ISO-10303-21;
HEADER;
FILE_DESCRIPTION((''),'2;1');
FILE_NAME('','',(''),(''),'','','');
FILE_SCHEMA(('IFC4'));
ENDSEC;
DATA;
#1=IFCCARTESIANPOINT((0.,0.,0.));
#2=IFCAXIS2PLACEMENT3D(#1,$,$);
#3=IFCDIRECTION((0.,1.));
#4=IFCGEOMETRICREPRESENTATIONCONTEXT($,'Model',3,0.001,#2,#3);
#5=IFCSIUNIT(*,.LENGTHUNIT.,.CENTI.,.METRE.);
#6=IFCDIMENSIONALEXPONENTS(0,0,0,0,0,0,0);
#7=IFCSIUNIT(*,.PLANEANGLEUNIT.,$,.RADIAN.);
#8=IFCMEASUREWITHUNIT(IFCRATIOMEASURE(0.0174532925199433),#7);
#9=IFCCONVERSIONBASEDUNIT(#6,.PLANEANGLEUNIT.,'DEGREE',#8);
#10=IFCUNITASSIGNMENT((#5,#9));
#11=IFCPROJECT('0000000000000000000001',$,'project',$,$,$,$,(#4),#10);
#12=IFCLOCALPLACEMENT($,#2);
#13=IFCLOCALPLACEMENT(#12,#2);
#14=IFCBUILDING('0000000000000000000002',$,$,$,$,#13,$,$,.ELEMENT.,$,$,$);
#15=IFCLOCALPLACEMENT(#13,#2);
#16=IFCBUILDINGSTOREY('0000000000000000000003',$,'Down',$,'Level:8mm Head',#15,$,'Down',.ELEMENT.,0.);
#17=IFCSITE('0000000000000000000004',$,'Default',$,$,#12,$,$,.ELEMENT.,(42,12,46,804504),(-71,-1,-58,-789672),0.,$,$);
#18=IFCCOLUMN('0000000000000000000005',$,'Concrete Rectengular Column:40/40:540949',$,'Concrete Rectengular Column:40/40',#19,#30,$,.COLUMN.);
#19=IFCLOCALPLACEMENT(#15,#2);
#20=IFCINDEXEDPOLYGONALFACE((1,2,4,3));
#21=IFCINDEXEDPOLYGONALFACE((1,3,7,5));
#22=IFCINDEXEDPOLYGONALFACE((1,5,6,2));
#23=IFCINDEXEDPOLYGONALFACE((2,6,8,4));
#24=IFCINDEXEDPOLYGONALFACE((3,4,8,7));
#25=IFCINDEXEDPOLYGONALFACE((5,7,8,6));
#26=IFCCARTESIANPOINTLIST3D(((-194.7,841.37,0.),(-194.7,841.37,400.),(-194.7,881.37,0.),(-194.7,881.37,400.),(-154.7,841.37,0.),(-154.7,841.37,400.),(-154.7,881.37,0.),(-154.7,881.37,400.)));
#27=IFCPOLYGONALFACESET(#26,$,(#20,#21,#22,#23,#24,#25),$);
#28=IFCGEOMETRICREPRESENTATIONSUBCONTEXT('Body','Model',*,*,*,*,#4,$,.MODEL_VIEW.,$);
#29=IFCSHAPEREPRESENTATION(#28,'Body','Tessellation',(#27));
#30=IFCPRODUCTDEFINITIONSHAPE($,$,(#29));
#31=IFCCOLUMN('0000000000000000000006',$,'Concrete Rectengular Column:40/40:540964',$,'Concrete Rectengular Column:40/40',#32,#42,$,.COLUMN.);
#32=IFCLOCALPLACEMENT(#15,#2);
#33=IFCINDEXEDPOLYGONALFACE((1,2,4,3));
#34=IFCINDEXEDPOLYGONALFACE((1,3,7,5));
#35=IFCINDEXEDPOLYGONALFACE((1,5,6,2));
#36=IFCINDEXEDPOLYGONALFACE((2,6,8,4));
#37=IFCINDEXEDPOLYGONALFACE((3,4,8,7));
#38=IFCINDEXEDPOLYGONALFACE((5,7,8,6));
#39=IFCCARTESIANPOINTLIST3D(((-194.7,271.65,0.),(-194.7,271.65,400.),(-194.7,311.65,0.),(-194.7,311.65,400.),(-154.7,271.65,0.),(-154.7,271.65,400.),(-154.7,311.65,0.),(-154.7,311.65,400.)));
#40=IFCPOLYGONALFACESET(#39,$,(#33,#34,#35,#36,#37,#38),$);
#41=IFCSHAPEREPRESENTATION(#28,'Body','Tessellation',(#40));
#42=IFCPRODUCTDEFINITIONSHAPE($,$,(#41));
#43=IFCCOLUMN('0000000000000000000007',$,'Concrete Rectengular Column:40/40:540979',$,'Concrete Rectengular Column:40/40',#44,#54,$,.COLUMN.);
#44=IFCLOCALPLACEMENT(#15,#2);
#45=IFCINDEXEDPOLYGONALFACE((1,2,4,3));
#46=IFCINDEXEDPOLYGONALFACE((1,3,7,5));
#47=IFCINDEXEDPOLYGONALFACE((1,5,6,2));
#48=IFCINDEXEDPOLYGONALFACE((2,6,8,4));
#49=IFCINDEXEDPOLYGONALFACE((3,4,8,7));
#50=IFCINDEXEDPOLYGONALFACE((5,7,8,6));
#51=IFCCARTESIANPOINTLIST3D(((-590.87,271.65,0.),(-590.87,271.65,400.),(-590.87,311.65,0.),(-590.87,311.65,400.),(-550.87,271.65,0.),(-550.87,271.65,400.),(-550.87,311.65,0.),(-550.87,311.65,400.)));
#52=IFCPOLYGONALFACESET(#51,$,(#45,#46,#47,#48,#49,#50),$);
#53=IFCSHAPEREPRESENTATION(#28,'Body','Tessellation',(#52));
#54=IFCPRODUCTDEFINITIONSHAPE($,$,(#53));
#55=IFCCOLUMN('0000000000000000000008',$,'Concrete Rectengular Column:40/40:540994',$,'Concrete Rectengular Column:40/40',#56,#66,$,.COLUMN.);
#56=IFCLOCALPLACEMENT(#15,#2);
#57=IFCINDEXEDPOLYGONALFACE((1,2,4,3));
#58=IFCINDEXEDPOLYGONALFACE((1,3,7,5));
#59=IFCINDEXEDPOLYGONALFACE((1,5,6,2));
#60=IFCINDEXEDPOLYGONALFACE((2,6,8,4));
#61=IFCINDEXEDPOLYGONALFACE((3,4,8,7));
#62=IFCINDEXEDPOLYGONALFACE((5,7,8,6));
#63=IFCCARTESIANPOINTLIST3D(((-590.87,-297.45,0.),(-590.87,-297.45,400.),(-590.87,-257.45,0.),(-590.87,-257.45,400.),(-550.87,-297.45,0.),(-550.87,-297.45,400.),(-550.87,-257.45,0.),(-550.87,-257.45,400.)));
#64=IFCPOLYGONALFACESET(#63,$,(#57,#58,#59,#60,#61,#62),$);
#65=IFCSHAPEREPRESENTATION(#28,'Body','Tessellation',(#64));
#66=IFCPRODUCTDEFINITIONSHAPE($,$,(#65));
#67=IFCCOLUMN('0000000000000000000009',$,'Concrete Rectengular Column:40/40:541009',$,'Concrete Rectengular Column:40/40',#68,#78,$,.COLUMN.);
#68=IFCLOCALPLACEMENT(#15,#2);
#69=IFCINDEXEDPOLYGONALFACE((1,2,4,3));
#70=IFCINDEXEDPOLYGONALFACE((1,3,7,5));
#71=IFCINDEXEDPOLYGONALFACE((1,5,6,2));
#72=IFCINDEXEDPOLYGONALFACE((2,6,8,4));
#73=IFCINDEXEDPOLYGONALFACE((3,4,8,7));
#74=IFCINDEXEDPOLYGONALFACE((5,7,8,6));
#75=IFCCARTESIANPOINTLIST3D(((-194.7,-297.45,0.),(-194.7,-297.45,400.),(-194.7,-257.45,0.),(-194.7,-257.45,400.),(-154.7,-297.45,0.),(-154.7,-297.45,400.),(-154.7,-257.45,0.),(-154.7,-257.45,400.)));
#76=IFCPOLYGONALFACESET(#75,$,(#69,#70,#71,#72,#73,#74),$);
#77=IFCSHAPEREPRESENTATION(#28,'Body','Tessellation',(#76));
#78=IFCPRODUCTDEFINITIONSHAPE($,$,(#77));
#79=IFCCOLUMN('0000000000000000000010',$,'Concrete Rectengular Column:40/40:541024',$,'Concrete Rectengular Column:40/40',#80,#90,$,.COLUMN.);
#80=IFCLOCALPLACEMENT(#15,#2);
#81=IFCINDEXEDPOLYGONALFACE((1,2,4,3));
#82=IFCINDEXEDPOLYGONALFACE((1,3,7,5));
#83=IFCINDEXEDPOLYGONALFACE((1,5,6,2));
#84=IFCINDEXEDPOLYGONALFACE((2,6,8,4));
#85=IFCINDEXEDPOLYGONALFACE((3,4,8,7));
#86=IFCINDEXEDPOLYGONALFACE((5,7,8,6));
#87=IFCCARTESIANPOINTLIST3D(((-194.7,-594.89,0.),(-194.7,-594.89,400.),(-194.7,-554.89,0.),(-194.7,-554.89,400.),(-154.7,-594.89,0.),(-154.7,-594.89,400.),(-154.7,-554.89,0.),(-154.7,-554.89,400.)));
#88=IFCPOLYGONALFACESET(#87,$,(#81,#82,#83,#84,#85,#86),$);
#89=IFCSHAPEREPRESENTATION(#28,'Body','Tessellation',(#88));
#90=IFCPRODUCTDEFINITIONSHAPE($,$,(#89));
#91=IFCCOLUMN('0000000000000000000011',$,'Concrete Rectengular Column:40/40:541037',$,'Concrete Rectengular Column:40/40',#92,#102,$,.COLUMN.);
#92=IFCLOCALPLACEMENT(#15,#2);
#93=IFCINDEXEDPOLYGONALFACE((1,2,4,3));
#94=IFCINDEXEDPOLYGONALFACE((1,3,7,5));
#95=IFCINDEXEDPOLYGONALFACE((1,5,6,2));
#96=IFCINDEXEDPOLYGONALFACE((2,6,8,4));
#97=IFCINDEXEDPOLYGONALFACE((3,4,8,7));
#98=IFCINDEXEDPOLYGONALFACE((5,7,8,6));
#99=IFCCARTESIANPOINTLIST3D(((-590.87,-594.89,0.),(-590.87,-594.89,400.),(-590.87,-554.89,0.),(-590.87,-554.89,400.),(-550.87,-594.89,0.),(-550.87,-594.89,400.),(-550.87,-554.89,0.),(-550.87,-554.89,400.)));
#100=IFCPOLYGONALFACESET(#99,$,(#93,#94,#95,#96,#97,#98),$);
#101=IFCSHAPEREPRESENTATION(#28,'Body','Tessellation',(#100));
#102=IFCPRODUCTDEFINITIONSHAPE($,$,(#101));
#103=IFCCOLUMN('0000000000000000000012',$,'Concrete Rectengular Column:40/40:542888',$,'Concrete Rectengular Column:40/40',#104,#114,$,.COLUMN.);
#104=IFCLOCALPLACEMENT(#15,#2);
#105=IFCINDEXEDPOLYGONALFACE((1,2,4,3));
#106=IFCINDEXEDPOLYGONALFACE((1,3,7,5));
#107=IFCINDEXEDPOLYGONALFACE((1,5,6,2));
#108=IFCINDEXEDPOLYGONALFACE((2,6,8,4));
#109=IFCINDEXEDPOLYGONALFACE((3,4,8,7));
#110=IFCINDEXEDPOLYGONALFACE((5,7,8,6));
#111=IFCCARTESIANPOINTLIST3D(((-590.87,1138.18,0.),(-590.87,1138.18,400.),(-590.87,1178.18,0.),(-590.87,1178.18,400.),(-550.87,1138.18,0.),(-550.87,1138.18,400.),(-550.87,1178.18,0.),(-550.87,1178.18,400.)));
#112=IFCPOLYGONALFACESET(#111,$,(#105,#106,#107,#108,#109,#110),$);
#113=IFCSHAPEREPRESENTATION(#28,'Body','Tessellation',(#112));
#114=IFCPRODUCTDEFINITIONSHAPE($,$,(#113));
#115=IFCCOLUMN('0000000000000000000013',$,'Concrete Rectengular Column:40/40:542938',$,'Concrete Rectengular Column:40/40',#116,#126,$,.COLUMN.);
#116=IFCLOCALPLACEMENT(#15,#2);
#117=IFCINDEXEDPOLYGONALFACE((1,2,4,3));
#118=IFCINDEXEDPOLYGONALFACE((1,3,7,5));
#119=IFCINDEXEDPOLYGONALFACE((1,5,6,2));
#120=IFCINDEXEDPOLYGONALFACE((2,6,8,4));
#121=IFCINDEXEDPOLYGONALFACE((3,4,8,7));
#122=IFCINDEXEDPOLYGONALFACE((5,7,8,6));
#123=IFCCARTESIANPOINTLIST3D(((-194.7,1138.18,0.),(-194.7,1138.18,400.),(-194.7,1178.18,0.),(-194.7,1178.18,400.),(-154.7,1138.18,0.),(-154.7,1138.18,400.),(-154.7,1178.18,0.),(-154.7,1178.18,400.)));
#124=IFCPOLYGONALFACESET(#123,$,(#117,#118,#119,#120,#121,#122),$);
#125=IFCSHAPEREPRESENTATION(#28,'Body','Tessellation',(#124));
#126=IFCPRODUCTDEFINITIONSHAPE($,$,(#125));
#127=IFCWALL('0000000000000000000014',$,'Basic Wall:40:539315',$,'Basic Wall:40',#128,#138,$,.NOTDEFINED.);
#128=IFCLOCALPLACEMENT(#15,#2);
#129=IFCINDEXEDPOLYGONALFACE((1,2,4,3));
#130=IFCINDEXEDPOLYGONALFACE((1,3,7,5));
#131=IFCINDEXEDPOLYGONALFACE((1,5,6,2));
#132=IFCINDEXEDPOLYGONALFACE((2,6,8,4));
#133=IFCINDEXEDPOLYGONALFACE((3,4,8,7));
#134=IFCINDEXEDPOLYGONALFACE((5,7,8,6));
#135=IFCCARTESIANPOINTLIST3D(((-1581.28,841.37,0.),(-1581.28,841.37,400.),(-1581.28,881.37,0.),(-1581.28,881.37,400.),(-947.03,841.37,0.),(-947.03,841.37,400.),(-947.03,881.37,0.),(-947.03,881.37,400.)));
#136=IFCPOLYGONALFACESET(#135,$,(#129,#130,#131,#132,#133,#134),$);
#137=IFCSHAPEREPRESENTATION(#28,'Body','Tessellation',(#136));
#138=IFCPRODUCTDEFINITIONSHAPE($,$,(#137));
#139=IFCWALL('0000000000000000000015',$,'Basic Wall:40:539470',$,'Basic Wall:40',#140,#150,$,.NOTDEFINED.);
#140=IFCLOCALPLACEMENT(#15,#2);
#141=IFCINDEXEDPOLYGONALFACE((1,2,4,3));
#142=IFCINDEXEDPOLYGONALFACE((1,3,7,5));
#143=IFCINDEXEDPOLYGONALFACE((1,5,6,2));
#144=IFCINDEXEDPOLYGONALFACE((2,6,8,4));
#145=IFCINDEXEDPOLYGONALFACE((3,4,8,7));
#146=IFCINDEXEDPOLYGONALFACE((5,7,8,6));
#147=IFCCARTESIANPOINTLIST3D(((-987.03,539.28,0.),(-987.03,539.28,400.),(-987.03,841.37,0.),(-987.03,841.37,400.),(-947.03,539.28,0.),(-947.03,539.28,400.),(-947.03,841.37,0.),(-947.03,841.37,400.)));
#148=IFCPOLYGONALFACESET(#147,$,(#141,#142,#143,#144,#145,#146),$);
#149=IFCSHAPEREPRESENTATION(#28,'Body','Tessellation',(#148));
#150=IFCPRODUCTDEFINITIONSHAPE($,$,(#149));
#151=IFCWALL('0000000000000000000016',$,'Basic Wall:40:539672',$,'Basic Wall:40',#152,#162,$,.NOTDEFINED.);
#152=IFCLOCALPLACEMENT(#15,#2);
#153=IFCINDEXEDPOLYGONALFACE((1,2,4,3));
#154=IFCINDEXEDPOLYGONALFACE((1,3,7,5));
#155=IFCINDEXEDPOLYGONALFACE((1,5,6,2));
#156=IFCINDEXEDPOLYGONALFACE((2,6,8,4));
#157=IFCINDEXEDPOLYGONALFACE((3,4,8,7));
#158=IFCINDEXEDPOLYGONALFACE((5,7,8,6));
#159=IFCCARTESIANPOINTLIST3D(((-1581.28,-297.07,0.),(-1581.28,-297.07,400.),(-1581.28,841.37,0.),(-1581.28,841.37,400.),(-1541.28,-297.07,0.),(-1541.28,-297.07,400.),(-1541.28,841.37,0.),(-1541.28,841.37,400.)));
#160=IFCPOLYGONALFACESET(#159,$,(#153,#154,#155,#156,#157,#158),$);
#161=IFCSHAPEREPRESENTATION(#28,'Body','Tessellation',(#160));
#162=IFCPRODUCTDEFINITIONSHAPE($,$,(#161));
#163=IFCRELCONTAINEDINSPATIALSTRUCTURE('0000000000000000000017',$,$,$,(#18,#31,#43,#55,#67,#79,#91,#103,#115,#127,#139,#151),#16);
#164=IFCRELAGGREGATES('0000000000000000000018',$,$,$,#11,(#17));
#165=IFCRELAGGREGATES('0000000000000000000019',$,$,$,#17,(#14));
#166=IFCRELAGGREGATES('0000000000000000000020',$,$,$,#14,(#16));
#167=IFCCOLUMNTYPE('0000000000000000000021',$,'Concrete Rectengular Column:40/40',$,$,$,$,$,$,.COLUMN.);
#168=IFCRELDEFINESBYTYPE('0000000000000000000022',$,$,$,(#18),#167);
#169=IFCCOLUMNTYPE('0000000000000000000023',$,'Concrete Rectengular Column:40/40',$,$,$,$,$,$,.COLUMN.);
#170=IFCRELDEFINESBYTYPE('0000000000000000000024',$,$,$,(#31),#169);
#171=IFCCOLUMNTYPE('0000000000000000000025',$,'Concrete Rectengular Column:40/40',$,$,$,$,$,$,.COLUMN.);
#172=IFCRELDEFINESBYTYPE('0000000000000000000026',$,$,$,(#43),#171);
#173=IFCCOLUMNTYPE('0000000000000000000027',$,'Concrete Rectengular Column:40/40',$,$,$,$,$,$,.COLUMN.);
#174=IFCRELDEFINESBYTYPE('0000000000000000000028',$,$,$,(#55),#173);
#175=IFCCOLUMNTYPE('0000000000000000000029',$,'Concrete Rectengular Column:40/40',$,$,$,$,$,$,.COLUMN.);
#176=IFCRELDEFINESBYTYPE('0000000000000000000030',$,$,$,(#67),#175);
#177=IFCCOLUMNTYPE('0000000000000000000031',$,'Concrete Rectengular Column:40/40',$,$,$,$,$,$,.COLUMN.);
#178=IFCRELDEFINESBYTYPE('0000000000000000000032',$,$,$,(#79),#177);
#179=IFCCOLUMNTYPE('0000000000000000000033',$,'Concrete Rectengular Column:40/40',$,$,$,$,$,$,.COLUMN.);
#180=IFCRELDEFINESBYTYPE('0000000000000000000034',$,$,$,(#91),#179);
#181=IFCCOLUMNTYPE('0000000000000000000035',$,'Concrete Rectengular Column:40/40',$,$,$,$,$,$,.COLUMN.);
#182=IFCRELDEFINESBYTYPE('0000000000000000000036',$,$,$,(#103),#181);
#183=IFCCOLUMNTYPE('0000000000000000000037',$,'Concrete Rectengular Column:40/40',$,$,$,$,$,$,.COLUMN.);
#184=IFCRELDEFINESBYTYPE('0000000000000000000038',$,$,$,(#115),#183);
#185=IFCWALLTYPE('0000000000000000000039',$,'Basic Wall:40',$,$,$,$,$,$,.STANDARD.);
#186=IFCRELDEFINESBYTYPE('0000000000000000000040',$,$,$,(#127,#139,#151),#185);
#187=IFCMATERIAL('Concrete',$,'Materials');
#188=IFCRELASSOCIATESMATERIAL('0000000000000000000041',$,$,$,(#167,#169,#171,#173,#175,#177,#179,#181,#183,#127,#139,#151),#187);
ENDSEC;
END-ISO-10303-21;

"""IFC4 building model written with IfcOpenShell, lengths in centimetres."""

from ifc_helpers import new_model, entity, si_unit, converted_unit, direction, frame, origin, place, context, subcontext, project, spatial, indexed_curve, outline, extrude, source, transform, mapped, material, type_object, type_shapes, element, save


model = new_model("IFC4")

# Units and contexts
model_context = context("Model", 3, precision=0.001, world=origin(), true_north=direction((0.0, 1.0)))
body_context = subcontext(model_context, "Body", "Model", "MODEL_VIEW")
ifc_project = project(units=[si_unit("LENGTHUNIT", "METRE", prefix="CENTI"), converted_unit("PLANEANGLEUNIT", "DEGREE", entity("IfcRatioMeasure", 0.0174532925199433), si_unit("PLANEANGLEUNIT", "RADIAN"), dimensions=[0, 0, 0, 0, 0, 0, 0])], contexts=[model_context])

# Site, building, storey
site_placement = place(None, origin())
site = spatial("IfcSite", under=ifc_project, at=site_placement, Name="Default", CompositionType="ELEMENT", RefLatitude=(42, 12, 46, 804504), RefLongitude=(-71, -1, -58, -789672), RefElevation=0.0)
building_placement = place(site_placement, origin())
building = spatial("IfcBuilding", under=site, at=building_placement, CompositionType="ELEMENT")
storey_placement = place(building_placement, origin())
storey = spatial("IfcBuildingStorey", under=building, at=storey_placement, Name="Down", ObjectType="Level:8mm Head", LongName="Down", CompositionType="ELEMENT", Elevation=0.0)

# Columns
ifc_material = material(Name="Concrete", Category="Materials")
column_type_1 = type_object("IfcColumnType", Name="Concrete Rectengular Column:40/40", PredefinedType="COLUMN", material=ifc_material)
shared_shape_1 = source(origin(), body_context, "Body", "SweptSolid", [
    extrude(outline(indexed_curve([(-20.0, -20.0), (20.0, -20.0), (20.0, 20.0), (-20.0, 20.0), (-20.0, -20.0)], self_intersect=False)), frame((-174.7, 861.37, 0.0), z_axis=(0.0, 0.0, 1.0), x_axis=(0.0, -1.0, 0.0)), (0.0, 0.0, 1.0), 400.0),
])
type_shapes(column_type_1, [shared_shape_1])
column_1_placement = place(storey_placement, origin())
element("IfcColumn", 1, at=column_1_placement, inside=storey, type_object=column_type_1, Name="Concrete Rectengular Column:40/40:540949", ObjectType="Concrete Rectengular Column:40/40", PredefinedType="COLUMN", context=body_context, shape_type="MappedRepresentation", body=[
    mapped(shared_shape_1, transform((0.0, 0.0, 0.0), scale=1.0)),
])
column_type_2 = type_object("IfcColumnType", Name="Concrete Rectengular Column:40/40", PredefinedType="COLUMN", material=ifc_material)
shared_shape_2 = source(origin(), body_context, "Body", "SweptSolid", [
    extrude(outline(indexed_curve([(-20.0, -20.0), (20.0, -20.0), (20.0, 20.0), (-20.0, 20.0), (-20.0, -20.0)], self_intersect=False)), frame((-174.7, 291.65, 0.0), z_axis=(0.0, 0.0, 1.0), x_axis=(0.0, -1.0, 0.0)), (0.0, 0.0, 1.0), 400.0),
])
type_shapes(column_type_2, [shared_shape_2])
column_2_placement = place(storey_placement, origin())
element("IfcColumn", 2, at=column_2_placement, inside=storey, type_object=column_type_2, Name="Concrete Rectengular Column:40/40:540964", ObjectType="Concrete Rectengular Column:40/40", PredefinedType="COLUMN", context=body_context, shape_type="MappedRepresentation", body=[
    mapped(shared_shape_2, transform((0.0, 0.0, 0.0), scale=1.0)),
])
column_type_3 = type_object("IfcColumnType", Name="Concrete Rectengular Column:40/40", PredefinedType="COLUMN", material=ifc_material)
shared_shape_3 = source(origin(), body_context, "Body", "SweptSolid", [
    extrude(outline(indexed_curve([(-20.0, -20.0), (20.0, -20.0), (20.0, 20.0), (-20.0, 20.0), (-20.0, -20.0)], self_intersect=False)), frame((-570.87, 291.65, 0.0), z_axis=(0.0, 0.0, 1.0), x_axis=(0.0, -1.0, 0.0)), (0.0, 0.0, 1.0), 400.0),
])
type_shapes(column_type_3, [shared_shape_3])
column_3_placement = place(storey_placement, origin())
element("IfcColumn", 3, at=column_3_placement, inside=storey, type_object=column_type_3, Name="Concrete Rectengular Column:40/40:540979", ObjectType="Concrete Rectengular Column:40/40", PredefinedType="COLUMN", context=body_context, shape_type="MappedRepresentation", body=[
    mapped(shared_shape_3, transform((0.0, 0.0, 0.0), scale=1.0)),
])
column_type_4 = type_object("IfcColumnType", Name="Concrete Rectengular Column:40/40", PredefinedType="COLUMN", material=ifc_material)
shared_shape_4 = source(origin(), body_context, "Body", "SweptSolid", [
    extrude(outline(indexed_curve([(-20.0, -20.0), (20.0, -20.0), (20.0, 20.0), (-20.0, 20.0), (-20.0, -20.0)], self_intersect=False)), frame((-570.87, -277.45, 0.0), z_axis=(0.0, 0.0, 1.0), x_axis=(0.0, -1.0, 0.0)), (0.0, 0.0, 1.0), 400.0),
])
type_shapes(column_type_4, [shared_shape_4])
column_4_placement = place(storey_placement, origin())
element("IfcColumn", 4, at=column_4_placement, inside=storey, type_object=column_type_4, Name="Concrete Rectengular Column:40/40:540994", ObjectType="Concrete Rectengular Column:40/40", PredefinedType="COLUMN", context=body_context, shape_type="MappedRepresentation", body=[
    mapped(shared_shape_4, transform((0.0, 0.0, 0.0), scale=1.0)),
])
column_type_5 = type_object("IfcColumnType", Name="Concrete Rectengular Column:40/40", PredefinedType="COLUMN", material=ifc_material)
shared_shape_5 = source(origin(), body_context, "Body", "SweptSolid", [
    extrude(outline(indexed_curve([(-20.0, -20.0), (20.0, -20.0), (20.0, 20.0), (-20.0, 20.0), (-20.0, -20.0)], self_intersect=False)), frame((-174.7, -277.45, 0.0), z_axis=(0.0, 0.0, 1.0), x_axis=(0.0, -1.0, 0.0)), (0.0, 0.0, 1.0), 400.0),
])
type_shapes(column_type_5, [shared_shape_5])
column_5_placement = place(storey_placement, origin())
element("IfcColumn", 5, at=column_5_placement, inside=storey, type_object=column_type_5, Name="Concrete Rectengular Column:40/40:541009", ObjectType="Concrete Rectengular Column:40/40", PredefinedType="COLUMN", context=body_context, shape_type="MappedRepresentation", body=[
    mapped(shared_shape_5, transform((0.0, 0.0, 0.0), scale=1.0)),
])
column_type_6 = type_object("IfcColumnType", Name="Concrete Rectengular Column:40/40", PredefinedType="COLUMN", material=ifc_material)
shared_shape_6 = source(origin(), body_context, "Body", "SweptSolid", [
    extrude(outline(indexed_curve([(-20.0, -20.0), (20.0, -20.0), (20.0, 20.0), (-20.0, 20.0), (-20.0, -20.0)], self_intersect=False)), frame((-174.7, -574.89, 0.0), z_axis=(0.0, 0.0, 1.0), x_axis=(0.0, -1.0, 0.0)), (0.0, 0.0, 1.0), 400.0),
])
type_shapes(column_type_6, [shared_shape_6])
column_6_placement = place(storey_placement, origin())
element("IfcColumn", 6, at=column_6_placement, inside=storey, type_object=column_type_6, Name="Concrete Rectengular Column:40/40:541024", ObjectType="Concrete Rectengular Column:40/40", PredefinedType="COLUMN", context=body_context, shape_type="MappedRepresentation", body=[
    mapped(shared_shape_6, transform((0.0, 0.0, 0.0), scale=1.0)),
])
column_type_7 = type_object("IfcColumnType", Name="Concrete Rectengular Column:40/40", PredefinedType="COLUMN", material=ifc_material)
shared_shape_7 = source(origin(), body_context, "Body", "SweptSolid", [
    extrude(outline(indexed_curve([(-20.0, -20.0), (20.0, -20.0), (20.0, 20.0), (-20.0, 20.0), (-20.0, -20.0)], self_intersect=False)), frame((-570.87, -574.89, 0.0), z_axis=(0.0, 0.0, 1.0), x_axis=(0.0, -1.0, 0.0)), (0.0, 0.0, 1.0), 400.0),
])
type_shapes(column_type_7, [shared_shape_7])
column_7_placement = place(storey_placement, origin())
element("IfcColumn", 7, at=column_7_placement, inside=storey, type_object=column_type_7, Name="Concrete Rectengular Column:40/40:541037", ObjectType="Concrete Rectengular Column:40/40", PredefinedType="COLUMN", context=body_context, shape_type="MappedRepresentation", body=[
    mapped(shared_shape_7, transform((0.0, 0.0, 0.0), scale=1.0)),
])
column_type_8 = type_object("IfcColumnType", Name="Concrete Rectengular Column:40/40", PredefinedType="COLUMN", material=ifc_material)
shared_shape_8 = source(origin(), body_context, "Body", "SweptSolid", [
    extrude(outline(indexed_curve([(-20.0, -20.0), (20.0, -20.0), (20.0, 20.0), (-20.0, 20.0), (-20.0, -20.0)], self_intersect=False)), frame((-570.87, 1158.18, 0.0), z_axis=(0.0, 0.0, 1.0), x_axis=(0.0, -1.0, 0.0)), (0.0, 0.0, 1.0), 400.0),
])
type_shapes(column_type_8, [shared_shape_8])
column_8_placement = place(storey_placement, origin())
element("IfcColumn", 8, at=column_8_placement, inside=storey, type_object=column_type_8, Name="Concrete Rectengular Column:40/40:542888", ObjectType="Concrete Rectengular Column:40/40", PredefinedType="COLUMN", context=body_context, shape_type="MappedRepresentation", body=[
    mapped(shared_shape_8, transform((0.0, 0.0, 0.0), scale=1.0)),
])
column_type_9 = type_object("IfcColumnType", Name="Concrete Rectengular Column:40/40", PredefinedType="COLUMN", material=ifc_material)
shared_shape_9 = source(origin(), body_context, "Body", "SweptSolid", [
    extrude(outline(indexed_curve([(-20.0, -20.0), (20.0, -20.0), (20.0, 20.0), (-20.0, 20.0), (-20.0, -20.0)], self_intersect=False)), frame((-174.7, 1158.18, 0.0), z_axis=(0.0, 0.0, 1.0), x_axis=(0.0, -1.0, 0.0)), (0.0, 0.0, 1.0), 400.0),
])
type_shapes(column_type_9, [shared_shape_9])
column_9_placement = place(storey_placement, origin())
element("IfcColumn", 9, at=column_9_placement, inside=storey, type_object=column_type_9, Name="Concrete Rectengular Column:40/40:542938", ObjectType="Concrete Rectengular Column:40/40", PredefinedType="COLUMN", context=body_context, shape_type="MappedRepresentation", body=[
    mapped(shared_shape_9, transform((0.0, 0.0, 0.0), scale=1.0)),
])

# Walls
wall_type_1 = type_object("IfcWallType", Name="Basic Wall:40", PredefinedType="STANDARD")
wall_1_placement = place(storey_placement, frame((-1581.28, 861.37, 0.0)))
element("IfcWall", 10, at=wall_1_placement, inside=storey, type_object=wall_type_1, material=ifc_material, Name="Basic Wall:40:539315", ObjectType="Basic Wall:40", PredefinedType="NOTDEFINED", context=body_context, shape_type="SweptSolid", body=[
    extrude(outline(indexed_curve([(634.25, 20.0), (0.0, 20.0), (0.0, -20.0), (634.25, -20.0), (634.25, 20.0)], self_intersect=False)), origin(), (0.0, 0.0, 1.0), 400.0),
])
wall_2_placement = place(storey_placement, frame((-967.03, 841.37, 0.0), z_axis=(0.0, 0.0, 1.0), x_axis=(0.0, -1.0, 0.0)))
element("IfcWall", 11, at=wall_2_placement, inside=storey, type_object=wall_type_1, material=ifc_material, Name="Basic Wall:40:539470", ObjectType="Basic Wall:40", PredefinedType="NOTDEFINED", context=body_context, shape_type="SweptSolid", body=[
    extrude(outline(indexed_curve([(302.09, 20.0), (0.0, 20.0), (0.0, -20.0), (302.09, -20.0), (302.09, 20.0)], self_intersect=False)), origin(), (0.0, 0.0, 1.0), 400.0),
])
wall_3_placement = place(storey_placement, frame((-1561.28, 841.37, 0.0), z_axis=(0.0, 0.0, 1.0), x_axis=(0.0, -1.0, 0.0)))
element("IfcWall", 12, at=wall_3_placement, inside=storey, type_object=wall_type_1, material=ifc_material, Name="Basic Wall:40:539672", ObjectType="Basic Wall:40", PredefinedType="NOTDEFINED", context=body_context, shape_type="SweptSolid", body=[
    extrude(outline(indexed_curve([(1138.44, 20.0), (0.0, 20.0), (0.0, -20.0), (1138.44, -20.0), (1138.44, 20.0)], self_intersect=False)), origin(), (0.0, 0.0, 1.0), 400.0),
])

save(model, "model.ifc")
